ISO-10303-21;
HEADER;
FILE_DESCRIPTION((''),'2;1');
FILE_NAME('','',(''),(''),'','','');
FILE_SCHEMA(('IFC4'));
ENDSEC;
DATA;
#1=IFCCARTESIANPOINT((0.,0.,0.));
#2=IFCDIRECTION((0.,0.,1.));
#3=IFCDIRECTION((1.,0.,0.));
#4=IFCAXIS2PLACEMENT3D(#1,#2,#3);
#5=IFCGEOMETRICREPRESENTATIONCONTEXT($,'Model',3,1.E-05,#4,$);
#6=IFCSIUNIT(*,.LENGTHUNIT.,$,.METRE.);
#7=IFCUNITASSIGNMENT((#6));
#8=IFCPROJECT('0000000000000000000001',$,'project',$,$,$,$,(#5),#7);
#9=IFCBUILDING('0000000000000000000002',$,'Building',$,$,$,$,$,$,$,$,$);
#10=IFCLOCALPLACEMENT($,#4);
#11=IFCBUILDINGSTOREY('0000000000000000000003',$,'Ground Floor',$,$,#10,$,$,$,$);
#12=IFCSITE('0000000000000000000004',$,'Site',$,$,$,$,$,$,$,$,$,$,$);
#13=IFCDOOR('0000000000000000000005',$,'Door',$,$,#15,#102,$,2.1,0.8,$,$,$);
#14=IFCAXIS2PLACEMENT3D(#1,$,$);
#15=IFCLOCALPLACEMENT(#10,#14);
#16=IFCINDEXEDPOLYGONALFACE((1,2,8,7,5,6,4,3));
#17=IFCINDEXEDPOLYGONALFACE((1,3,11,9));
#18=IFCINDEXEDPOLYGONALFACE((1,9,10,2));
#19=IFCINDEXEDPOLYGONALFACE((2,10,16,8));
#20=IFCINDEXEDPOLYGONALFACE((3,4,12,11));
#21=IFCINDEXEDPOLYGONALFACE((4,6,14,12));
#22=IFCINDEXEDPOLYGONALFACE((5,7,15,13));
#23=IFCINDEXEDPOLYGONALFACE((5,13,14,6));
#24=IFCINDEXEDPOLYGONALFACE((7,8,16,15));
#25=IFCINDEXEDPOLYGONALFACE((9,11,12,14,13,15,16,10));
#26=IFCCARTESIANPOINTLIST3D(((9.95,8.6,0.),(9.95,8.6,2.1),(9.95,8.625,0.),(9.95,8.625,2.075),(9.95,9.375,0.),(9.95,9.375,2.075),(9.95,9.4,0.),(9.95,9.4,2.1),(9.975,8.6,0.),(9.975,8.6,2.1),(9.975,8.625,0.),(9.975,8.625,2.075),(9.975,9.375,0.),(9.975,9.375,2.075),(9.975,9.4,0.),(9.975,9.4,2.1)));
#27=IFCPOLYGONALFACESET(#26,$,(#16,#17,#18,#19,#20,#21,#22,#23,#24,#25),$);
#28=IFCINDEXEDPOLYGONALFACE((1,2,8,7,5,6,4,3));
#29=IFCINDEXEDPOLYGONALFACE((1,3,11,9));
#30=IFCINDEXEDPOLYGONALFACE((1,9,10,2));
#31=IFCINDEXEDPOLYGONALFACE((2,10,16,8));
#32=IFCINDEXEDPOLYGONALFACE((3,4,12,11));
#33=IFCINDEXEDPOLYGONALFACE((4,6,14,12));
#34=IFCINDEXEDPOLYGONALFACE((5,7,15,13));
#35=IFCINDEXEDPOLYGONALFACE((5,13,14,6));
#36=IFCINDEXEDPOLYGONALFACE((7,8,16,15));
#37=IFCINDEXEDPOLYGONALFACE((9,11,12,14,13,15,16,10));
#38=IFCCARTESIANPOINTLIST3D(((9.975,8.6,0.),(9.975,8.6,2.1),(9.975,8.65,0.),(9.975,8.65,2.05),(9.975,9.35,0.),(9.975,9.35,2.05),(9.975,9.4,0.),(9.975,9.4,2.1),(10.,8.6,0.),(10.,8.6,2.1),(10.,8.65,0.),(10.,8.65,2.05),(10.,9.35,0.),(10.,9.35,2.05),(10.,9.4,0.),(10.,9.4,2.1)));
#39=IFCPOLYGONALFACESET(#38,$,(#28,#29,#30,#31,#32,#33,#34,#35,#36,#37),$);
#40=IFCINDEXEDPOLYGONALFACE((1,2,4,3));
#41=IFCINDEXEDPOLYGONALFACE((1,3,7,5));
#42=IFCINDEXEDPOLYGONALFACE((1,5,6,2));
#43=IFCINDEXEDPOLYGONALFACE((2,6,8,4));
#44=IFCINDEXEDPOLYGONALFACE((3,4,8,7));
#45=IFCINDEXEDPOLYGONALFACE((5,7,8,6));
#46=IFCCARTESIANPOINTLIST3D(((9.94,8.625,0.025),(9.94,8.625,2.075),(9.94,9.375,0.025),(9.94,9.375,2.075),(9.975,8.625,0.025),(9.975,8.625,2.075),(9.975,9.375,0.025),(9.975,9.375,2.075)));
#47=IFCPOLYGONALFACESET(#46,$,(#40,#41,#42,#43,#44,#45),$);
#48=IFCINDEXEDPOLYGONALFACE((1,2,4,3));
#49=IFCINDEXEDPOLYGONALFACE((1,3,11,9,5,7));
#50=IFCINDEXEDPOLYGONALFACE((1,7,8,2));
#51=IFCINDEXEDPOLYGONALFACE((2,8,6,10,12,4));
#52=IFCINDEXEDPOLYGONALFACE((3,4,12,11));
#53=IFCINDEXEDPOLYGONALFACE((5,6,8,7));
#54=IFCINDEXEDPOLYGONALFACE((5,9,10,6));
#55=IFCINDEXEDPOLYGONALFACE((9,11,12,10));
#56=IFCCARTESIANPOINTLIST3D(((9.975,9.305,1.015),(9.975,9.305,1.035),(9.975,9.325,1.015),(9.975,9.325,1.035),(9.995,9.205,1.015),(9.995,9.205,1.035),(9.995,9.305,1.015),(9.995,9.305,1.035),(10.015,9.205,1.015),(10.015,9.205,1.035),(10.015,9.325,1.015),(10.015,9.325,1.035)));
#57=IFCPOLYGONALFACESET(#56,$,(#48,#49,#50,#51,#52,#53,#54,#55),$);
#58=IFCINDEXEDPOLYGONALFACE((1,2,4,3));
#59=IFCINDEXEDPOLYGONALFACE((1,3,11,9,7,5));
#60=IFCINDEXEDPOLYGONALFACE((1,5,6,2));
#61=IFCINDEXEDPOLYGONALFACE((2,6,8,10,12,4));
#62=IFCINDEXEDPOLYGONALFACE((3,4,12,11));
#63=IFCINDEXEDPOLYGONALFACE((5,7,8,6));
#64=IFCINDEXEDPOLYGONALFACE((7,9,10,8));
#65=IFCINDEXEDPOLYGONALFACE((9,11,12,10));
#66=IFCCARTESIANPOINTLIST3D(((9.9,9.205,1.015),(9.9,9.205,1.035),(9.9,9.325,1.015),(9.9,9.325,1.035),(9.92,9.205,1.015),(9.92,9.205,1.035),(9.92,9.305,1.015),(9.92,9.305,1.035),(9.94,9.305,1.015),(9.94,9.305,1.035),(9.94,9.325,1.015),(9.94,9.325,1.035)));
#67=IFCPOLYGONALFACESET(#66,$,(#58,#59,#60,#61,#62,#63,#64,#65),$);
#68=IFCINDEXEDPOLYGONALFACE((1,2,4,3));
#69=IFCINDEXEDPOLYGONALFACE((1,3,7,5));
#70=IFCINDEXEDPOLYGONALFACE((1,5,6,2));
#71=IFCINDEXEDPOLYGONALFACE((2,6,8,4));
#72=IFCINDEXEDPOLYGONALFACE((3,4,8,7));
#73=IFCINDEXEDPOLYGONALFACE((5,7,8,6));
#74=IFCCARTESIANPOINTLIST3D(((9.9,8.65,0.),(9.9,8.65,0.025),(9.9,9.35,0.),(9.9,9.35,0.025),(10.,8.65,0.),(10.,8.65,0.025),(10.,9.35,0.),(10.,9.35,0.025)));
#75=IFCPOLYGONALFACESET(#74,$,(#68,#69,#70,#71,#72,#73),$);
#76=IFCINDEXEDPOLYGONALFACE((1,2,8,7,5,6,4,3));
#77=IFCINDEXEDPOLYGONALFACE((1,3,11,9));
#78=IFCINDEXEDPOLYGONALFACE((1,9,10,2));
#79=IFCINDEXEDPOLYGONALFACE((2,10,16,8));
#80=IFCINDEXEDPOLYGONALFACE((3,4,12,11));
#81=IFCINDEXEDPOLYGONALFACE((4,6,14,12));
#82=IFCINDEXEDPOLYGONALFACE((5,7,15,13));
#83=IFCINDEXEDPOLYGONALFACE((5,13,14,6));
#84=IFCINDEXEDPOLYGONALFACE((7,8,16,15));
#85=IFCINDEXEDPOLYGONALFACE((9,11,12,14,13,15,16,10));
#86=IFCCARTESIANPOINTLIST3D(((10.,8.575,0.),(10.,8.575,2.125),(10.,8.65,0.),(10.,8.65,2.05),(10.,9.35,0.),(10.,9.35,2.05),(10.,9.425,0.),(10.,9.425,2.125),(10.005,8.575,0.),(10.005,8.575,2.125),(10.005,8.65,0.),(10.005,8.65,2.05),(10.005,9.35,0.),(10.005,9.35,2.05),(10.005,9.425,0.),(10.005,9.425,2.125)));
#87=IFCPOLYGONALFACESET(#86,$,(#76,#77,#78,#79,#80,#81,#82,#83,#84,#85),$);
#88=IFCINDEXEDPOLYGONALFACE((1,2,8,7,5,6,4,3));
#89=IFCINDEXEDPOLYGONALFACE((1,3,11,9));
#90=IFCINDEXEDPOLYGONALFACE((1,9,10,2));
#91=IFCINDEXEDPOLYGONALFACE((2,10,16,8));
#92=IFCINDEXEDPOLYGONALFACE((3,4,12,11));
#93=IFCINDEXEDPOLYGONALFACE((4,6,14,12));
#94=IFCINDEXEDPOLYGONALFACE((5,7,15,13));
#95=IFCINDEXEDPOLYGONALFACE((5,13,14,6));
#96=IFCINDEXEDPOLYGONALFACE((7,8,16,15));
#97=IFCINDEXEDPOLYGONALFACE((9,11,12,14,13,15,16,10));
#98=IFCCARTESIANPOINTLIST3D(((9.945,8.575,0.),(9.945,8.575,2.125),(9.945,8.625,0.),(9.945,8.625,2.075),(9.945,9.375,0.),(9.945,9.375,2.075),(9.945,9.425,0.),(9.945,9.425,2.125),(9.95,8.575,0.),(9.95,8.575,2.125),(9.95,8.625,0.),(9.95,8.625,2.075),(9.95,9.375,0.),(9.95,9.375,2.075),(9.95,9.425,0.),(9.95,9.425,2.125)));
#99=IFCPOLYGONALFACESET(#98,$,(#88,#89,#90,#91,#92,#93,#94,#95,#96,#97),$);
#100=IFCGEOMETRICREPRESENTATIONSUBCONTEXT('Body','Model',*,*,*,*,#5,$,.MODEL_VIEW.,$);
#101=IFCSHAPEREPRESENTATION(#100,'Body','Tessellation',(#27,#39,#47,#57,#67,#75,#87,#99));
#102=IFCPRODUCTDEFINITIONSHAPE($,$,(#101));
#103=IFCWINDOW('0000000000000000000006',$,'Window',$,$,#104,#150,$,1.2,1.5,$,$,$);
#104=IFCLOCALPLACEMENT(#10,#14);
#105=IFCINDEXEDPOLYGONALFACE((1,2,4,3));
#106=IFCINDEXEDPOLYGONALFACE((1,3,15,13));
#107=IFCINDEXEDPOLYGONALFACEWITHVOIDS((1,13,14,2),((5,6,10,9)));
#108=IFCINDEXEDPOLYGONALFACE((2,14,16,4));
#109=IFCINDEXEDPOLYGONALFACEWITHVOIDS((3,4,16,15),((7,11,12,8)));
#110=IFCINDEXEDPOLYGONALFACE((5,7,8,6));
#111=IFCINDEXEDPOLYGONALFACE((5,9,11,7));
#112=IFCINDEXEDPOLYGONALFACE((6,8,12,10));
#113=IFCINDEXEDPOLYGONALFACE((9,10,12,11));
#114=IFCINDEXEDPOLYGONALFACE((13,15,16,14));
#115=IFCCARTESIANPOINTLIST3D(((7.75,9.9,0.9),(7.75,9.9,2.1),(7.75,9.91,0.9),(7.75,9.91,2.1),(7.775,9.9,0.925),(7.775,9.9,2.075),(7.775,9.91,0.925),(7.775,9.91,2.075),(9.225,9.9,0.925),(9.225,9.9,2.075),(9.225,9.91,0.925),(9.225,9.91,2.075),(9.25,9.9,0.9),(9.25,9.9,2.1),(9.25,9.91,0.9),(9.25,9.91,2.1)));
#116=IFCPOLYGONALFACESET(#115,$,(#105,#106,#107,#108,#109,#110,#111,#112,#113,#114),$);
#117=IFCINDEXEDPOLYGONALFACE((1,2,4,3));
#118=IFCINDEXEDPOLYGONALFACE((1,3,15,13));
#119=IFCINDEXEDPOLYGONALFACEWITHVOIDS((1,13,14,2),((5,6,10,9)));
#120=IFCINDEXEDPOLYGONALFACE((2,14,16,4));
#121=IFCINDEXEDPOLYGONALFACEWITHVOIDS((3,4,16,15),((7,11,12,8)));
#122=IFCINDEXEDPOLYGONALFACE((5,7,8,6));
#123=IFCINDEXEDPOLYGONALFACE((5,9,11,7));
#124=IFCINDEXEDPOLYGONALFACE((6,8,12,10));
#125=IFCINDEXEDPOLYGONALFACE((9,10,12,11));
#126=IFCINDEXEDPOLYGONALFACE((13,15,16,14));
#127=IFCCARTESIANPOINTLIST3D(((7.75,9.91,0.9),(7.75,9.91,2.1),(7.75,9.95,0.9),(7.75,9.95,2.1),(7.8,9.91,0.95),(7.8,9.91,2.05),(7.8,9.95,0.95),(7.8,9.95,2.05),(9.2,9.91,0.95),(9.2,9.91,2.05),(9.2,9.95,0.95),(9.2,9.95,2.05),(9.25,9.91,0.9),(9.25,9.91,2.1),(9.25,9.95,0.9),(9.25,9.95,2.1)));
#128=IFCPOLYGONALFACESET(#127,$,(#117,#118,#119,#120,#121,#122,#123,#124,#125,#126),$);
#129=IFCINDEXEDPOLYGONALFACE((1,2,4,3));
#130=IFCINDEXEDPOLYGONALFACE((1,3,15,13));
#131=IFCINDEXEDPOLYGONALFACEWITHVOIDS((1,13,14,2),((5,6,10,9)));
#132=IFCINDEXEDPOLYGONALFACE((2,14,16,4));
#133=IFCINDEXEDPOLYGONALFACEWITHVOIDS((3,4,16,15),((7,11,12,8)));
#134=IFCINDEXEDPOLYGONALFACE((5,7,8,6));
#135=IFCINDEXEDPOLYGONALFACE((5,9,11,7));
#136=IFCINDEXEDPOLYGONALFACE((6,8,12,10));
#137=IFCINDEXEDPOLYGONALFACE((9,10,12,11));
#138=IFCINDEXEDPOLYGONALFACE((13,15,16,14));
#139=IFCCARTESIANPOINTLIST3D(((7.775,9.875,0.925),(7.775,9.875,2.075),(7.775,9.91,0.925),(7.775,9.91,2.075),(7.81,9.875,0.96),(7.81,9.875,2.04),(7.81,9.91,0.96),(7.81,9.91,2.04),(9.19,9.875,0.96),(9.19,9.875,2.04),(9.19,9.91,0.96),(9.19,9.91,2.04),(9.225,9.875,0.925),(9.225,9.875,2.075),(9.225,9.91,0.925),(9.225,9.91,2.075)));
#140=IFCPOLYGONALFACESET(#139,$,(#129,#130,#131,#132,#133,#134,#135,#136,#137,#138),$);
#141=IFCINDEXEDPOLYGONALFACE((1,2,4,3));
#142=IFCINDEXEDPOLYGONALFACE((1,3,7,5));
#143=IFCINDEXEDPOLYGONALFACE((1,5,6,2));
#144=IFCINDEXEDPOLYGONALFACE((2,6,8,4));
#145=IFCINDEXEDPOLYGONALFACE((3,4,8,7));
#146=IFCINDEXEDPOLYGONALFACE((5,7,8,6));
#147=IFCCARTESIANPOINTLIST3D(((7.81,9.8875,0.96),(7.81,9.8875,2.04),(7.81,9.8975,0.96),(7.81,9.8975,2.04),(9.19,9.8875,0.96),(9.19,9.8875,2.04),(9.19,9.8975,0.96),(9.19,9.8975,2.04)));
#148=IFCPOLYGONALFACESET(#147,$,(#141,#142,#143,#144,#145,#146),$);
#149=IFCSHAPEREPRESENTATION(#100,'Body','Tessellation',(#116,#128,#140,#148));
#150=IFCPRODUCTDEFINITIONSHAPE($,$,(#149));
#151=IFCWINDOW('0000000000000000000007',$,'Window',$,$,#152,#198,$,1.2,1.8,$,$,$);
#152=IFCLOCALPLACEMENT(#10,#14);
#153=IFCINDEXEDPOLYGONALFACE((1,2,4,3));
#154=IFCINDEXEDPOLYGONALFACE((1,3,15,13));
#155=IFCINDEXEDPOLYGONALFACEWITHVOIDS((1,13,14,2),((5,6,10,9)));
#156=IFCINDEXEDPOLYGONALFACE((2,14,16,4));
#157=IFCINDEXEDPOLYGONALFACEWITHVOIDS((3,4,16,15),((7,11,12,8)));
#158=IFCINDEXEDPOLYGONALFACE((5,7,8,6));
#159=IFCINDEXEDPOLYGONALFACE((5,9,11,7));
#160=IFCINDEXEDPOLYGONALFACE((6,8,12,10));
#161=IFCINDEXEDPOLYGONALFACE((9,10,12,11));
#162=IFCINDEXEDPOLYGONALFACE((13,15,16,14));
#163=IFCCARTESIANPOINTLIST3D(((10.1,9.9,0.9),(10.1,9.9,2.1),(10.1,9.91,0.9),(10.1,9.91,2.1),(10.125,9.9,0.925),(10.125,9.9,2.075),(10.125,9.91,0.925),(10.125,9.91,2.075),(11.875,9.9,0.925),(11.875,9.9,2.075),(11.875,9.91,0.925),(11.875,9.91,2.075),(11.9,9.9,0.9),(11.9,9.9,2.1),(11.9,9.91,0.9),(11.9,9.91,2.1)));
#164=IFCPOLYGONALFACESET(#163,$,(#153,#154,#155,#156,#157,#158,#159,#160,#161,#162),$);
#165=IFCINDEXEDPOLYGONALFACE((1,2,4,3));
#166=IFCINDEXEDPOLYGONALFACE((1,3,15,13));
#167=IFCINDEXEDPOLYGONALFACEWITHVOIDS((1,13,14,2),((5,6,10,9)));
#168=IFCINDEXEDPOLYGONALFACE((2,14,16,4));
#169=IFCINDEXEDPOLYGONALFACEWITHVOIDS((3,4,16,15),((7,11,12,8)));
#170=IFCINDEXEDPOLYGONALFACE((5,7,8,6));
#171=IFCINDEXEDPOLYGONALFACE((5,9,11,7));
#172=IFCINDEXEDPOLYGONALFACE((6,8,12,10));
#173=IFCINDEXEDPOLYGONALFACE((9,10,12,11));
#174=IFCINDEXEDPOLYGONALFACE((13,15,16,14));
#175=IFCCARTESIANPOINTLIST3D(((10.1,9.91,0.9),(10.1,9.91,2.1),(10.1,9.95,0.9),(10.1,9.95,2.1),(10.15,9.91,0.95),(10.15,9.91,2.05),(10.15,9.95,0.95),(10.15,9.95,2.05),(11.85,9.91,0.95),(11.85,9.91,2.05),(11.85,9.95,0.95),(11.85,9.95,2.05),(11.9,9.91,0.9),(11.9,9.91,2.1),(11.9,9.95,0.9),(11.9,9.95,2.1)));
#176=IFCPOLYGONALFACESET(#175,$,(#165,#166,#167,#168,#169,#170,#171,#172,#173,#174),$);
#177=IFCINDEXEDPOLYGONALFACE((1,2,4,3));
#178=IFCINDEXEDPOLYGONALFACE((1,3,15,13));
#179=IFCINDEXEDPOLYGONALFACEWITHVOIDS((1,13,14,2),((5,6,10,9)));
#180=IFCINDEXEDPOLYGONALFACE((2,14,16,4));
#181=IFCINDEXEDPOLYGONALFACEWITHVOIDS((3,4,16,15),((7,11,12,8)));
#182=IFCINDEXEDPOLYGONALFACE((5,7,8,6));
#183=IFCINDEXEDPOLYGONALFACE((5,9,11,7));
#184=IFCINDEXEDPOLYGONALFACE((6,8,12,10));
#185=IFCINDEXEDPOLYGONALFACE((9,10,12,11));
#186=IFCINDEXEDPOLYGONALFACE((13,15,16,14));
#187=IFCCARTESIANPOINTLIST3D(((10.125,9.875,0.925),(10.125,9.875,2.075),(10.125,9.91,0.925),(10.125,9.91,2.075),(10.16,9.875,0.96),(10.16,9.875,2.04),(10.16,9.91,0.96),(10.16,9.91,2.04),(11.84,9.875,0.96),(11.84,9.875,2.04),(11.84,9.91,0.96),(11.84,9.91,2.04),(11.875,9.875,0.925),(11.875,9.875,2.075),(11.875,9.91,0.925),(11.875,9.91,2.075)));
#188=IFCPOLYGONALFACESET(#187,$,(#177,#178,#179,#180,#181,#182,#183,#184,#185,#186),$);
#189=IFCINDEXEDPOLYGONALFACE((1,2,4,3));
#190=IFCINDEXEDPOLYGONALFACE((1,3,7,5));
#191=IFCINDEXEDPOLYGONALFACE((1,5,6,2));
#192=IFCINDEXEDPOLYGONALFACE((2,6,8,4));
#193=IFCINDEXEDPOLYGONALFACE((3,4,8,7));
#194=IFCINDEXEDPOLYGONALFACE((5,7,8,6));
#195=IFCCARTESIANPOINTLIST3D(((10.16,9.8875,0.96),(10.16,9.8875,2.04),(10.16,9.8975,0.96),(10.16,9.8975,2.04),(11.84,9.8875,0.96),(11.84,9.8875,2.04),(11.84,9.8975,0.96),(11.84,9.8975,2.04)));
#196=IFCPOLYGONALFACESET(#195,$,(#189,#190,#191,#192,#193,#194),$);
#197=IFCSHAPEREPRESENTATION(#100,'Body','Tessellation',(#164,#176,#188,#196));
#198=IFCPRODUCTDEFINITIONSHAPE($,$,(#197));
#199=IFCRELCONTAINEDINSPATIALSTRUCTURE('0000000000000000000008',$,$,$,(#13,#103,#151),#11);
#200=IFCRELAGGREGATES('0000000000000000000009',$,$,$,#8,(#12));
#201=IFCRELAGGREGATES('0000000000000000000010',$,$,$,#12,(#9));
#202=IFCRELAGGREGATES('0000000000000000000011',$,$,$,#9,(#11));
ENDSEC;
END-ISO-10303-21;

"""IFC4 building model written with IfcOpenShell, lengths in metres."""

from ifc_helpers import new_model, si_unit, frame, origin_with_axes, place, context, subcontext, project, spatial, line, indexed_curve, outline, extrude, element, save


model = new_model("IFC4")

# Units and contexts
model_context = context("Model", 3, precision=1e-05, world=origin_with_axes())
body_context = subcontext(model_context, "Body", "Model", "MODEL_VIEW")
ifc_project = project(units=[si_unit("LENGTHUNIT", "METRE")], contexts=[model_context])

# Site, building, storey
site = spatial("IfcSite", under=ifc_project, Name="Site")
building = spatial("IfcBuilding", under=site, Name="Building")
storey_placement = place(None, origin_with_axes())
storey = spatial("IfcBuildingStorey", under=building, at=storey_placement, Name="Ground Floor")

# Door
door_1_placement = place(storey_placement, frame((10.0, 8.6, 0.0), z_axis=(0.0, 0.0, 1.0), x_axis=(0.0, 1.0, 0.0)))
element("IfcDoor", 1, at=door_1_placement, inside=storey, Name="Door", OverallHeight=2.1, OverallWidth=0.8, context=body_context, shape_type="SweptSolid", body=[
    extrude(outline(indexed_curve([(0.0, 0.0), (0.0, 2.1), (0.8, 2.1), (0.8, 0.0), (0.775, 0.0), (0.775, 2.075), (0.025, 2.075), (0.025, 0.0)], segments=[line(1, 2, 3, 4, 5, 6, 7, 8, 1)])), frame((0.0, 0.025, 0.0), z_axis=(0.0, -1.0, 0.0), x_axis=(1.0, 0.0, 0.0)), (0.0, 0.0, -1.0), 0.025),
    extrude(outline(indexed_curve([(0.0, 0.0), (0.0, 2.1), (0.8, 2.1), (0.8, 0.0), (0.75, 0.0), (0.75, 2.05), (0.05, 2.05), (0.05, 0.0)], segments=[line(1, 2, 3, 4, 5, 6, 7, 8, 1)])), frame((0.0, 0.0, 0.0), z_axis=(0.0, -1.0, 0.0), x_axis=(1.0, 0.0, 0.0)), (0.0, 0.0, -1.0), 0.025),
    extrude(outline(indexed_curve([(0.0, 0.0), (0.75, 0.0), (0.75, 0.035), (0.0, 0.035)], segments=[line(1, 2, 3, 4, 1)])), frame((0.025, 0.025, 0.025), z_axis=(0.0, 0.0, 1.0), x_axis=(1.0, 0.0, 0.0)), (0.0, 0.0, 1.0), 2.05),
    extrude(outline(indexed_curve([(0.0, 0.0), (0.0, -0.04), (-0.12, -0.04), (-0.12, -0.02), (-0.02, -0.02), (-0.02, 0.0)], segments=[line(1, 2, 3, 4, 5, 6, 1)])), frame((0.725, 0.025, 1.015), z_axis=(0.0, 0.0, 1.0), x_axis=(1.0, 0.0, 0.0)), (0.0, 0.0, 1.0), 0.02),
    extrude(outline(indexed_curve([(0.0, 0.0), (0.0, 0.04), (-0.12, 0.04), (-0.12, 0.02), (-0.02, 0.02), (-0.02, 0.0)], segments=[line(1, 2, 3, 4, 5, 6, 1)])), frame((0.725, 0.06, 1.015), z_axis=(0.0, 0.0, 1.0), x_axis=(1.0, 0.0, 0.0)), (0.0, 0.0, 1.0), 0.02),
    extrude(outline(indexed_curve([(0.0, 0.0), (0.7, 0.0), (0.7, 0.1), (0.0, 0.1)], segments=[line(1, 2, 3, 4, 1)])), frame((0.05, 0.0, 0.0), z_axis=(0.0, 0.0, 1.0), x_axis=(1.0, 0.0, 0.0)), (0.0, 0.0, 1.0), 0.025),
    extrude(outline(indexed_curve([(0.0, 0.0), (0.0, 2.125), (0.85, 2.125), (0.85, 0.0), (0.775, 0.0), (0.775, 2.05), (0.075, 2.05), (0.075, 0.0)], segments=[line(1, 2, 3, 4, 5, 6, 7, 8, 1)])), frame((-0.025, -0.005, 0.0), z_axis=(0.0, -1.0, 0.0), x_axis=(1.0, 0.0, 0.0)), (0.0, 0.0, -1.0), 0.005),
    extrude(outline(indexed_curve([(0.0, 0.0), (0.0, 2.125), (0.85, 2.125), (0.85, 0.0), (0.8, 0.0), (0.8, 2.075), (0.05, 2.075), (0.05, 0.0)], segments=[line(1, 2, 3, 4, 5, 6, 7, 8, 1)])), frame((-0.025, 0.05, 0.0), z_axis=(0.0, -1.0, 0.0), x_axis=(1.0, 0.0, 0.0)), (0.0, 0.0, -1.0), 0.005),
])

# Windows
window_1_placement = place(storey_placement, frame((9.25, 10.0, 0.9), z_axis=(0.0, 0.0, 1.0), x_axis=(-1.0, 0.0, 0.0)))
element("IfcWindow", 2, at=window_1_placement, inside=storey, Name="Window", OverallHeight=1.2, OverallWidth=1.5, context=body_context, shape_type="SweptSolid", body=[
    extrude(outline(indexed_curve([(0.0, 0.0), (1.5, 0.0), (1.5, 1.2), (0.0, 1.2)], segments=[line(1, 2, 3, 4, 1)]), holes=[indexed_curve([(0.025, 0.025), (1.475, 0.025), (1.475, 1.175), (0.025, 1.175)], segments=[line(1, 2, 3, 4, 1)])]), frame((0.0, 0.09, 0.0), z_axis=(0.0, -1.0, 0.0), x_axis=(1.0, 0.0, 0.0)), (0.0, 0.0, -1.0), 0.01),
    extrude(outline(indexed_curve([(0.0, 0.0), (1.5, 0.0), (1.5, 1.2), (0.0, 1.2)], segments=[line(1, 2, 3, 4, 1)]), holes=[indexed_curve([(0.05, 0.05), (1.45, 0.05), (1.45, 1.15), (0.05, 1.15)], segments=[line(1, 2, 3, 4, 1)])]), frame((0.0, 0.05, 0.0), z_axis=(0.0, -1.0, 0.0), x_axis=(1.0, 0.0, 0.0)), (0.0, 0.0, -1.0), 0.04),
    extrude(outline(indexed_curve([(0.0, 0.0), (1.45, 0.0), (1.45, 1.15), (0.0, 1.15)], segments=[line(1, 2, 3, 4, 1)]), holes=[indexed_curve([(0.035, 0.035), (1.415, 0.035), (1.415, 1.115), (0.035, 1.115)], segments=[line(1, 2, 3, 4, 1)])]), frame((0.025, 0.09, 0.025), z_axis=(0.0, -1.0, 0.0), x_axis=(1.0, 0.0, 0.0)), (0.0, 0.0, -1.0), 0.035),
    extrude(outline(indexed_curve([(0.035, 0.035), (1.415, 0.035), (1.415, 1.115), (0.035, 1.115)], segments=[line(1, 2, 3, 4, 1)])), frame((0.025, 0.1025, 0.025), z_axis=(0.0, -1.0, 0.0), x_axis=(1.0, 0.0, 0.0)), (0.0, 0.0, -1.0), 0.01),
])
window_2_placement = place(storey_placement, frame((11.9, 10.0, 0.9), z_axis=(0.0, 0.0, 1.0), x_axis=(-1.0, 0.0, 0.0)))
element("IfcWindow", 3, at=window_2_placement, inside=storey, Name="Window", OverallHeight=1.2, OverallWidth=1.8, context=body_context, shape_type="SweptSolid", body=[
    extrude(outline(indexed_curve([(0.0, 0.0), (1.8, 0.0), (1.8, 1.2), (0.0, 1.2)], segments=[line(1, 2, 3, 4, 1)]), holes=[indexed_curve([(0.025, 0.025), (1.775, 0.025), (1.775, 1.175), (0.025, 1.175)], segments=[line(1, 2, 3, 4, 1)])]), frame((0.0, 0.09, 0.0), z_axis=(0.0, -1.0, 0.0), x_axis=(1.0, 0.0, 0.0)), (0.0, 0.0, -1.0), 0.01),
    extrude(outline(indexed_curve([(0.0, 0.0), (1.8, 0.0), (1.8, 1.2), (0.0, 1.2)], segments=[line(1, 2, 3, 4, 1)]), holes=[indexed_curve([(0.05, 0.05), (1.75, 0.05), (1.75, 1.15), (0.05, 1.15)], segments=[line(1, 2, 3, 4, 1)])]), frame((0.0, 0.05, 0.0), z_axis=(0.0, -1.0, 0.0), x_axis=(1.0, 0.0, 0.0)), (0.0, 0.0, -1.0), 0.04),
    extrude(outline(indexed_curve([(0.0, 0.0), (1.75, 0.0), (1.75, 1.15), (0.0, 1.15)], segments=[line(1, 2, 3, 4, 1)]), holes=[indexed_curve([(0.035, 0.035), (1.715, 0.035), (1.715, 1.115), (0.035, 1.115)], segments=[line(1, 2, 3, 4, 1)])]), frame((0.025, 0.09, 0.025), z_axis=(0.0, -1.0, 0.0), x_axis=(1.0, 0.0, 0.0)), (0.0, 0.0, -1.0), 0.035),
    extrude(outline(indexed_curve([(0.035, 0.035), (1.715, 0.035), (1.715, 1.115), (0.035, 1.115)], segments=[line(1, 2, 3, 4, 1)])), frame((0.025, 0.1025, 0.025), z_axis=(0.0, -1.0, 0.0), x_axis=(1.0, 0.0, 0.0)), (0.0, 0.0, -1.0), 0.01),
])

save(model, "model.ifc")
